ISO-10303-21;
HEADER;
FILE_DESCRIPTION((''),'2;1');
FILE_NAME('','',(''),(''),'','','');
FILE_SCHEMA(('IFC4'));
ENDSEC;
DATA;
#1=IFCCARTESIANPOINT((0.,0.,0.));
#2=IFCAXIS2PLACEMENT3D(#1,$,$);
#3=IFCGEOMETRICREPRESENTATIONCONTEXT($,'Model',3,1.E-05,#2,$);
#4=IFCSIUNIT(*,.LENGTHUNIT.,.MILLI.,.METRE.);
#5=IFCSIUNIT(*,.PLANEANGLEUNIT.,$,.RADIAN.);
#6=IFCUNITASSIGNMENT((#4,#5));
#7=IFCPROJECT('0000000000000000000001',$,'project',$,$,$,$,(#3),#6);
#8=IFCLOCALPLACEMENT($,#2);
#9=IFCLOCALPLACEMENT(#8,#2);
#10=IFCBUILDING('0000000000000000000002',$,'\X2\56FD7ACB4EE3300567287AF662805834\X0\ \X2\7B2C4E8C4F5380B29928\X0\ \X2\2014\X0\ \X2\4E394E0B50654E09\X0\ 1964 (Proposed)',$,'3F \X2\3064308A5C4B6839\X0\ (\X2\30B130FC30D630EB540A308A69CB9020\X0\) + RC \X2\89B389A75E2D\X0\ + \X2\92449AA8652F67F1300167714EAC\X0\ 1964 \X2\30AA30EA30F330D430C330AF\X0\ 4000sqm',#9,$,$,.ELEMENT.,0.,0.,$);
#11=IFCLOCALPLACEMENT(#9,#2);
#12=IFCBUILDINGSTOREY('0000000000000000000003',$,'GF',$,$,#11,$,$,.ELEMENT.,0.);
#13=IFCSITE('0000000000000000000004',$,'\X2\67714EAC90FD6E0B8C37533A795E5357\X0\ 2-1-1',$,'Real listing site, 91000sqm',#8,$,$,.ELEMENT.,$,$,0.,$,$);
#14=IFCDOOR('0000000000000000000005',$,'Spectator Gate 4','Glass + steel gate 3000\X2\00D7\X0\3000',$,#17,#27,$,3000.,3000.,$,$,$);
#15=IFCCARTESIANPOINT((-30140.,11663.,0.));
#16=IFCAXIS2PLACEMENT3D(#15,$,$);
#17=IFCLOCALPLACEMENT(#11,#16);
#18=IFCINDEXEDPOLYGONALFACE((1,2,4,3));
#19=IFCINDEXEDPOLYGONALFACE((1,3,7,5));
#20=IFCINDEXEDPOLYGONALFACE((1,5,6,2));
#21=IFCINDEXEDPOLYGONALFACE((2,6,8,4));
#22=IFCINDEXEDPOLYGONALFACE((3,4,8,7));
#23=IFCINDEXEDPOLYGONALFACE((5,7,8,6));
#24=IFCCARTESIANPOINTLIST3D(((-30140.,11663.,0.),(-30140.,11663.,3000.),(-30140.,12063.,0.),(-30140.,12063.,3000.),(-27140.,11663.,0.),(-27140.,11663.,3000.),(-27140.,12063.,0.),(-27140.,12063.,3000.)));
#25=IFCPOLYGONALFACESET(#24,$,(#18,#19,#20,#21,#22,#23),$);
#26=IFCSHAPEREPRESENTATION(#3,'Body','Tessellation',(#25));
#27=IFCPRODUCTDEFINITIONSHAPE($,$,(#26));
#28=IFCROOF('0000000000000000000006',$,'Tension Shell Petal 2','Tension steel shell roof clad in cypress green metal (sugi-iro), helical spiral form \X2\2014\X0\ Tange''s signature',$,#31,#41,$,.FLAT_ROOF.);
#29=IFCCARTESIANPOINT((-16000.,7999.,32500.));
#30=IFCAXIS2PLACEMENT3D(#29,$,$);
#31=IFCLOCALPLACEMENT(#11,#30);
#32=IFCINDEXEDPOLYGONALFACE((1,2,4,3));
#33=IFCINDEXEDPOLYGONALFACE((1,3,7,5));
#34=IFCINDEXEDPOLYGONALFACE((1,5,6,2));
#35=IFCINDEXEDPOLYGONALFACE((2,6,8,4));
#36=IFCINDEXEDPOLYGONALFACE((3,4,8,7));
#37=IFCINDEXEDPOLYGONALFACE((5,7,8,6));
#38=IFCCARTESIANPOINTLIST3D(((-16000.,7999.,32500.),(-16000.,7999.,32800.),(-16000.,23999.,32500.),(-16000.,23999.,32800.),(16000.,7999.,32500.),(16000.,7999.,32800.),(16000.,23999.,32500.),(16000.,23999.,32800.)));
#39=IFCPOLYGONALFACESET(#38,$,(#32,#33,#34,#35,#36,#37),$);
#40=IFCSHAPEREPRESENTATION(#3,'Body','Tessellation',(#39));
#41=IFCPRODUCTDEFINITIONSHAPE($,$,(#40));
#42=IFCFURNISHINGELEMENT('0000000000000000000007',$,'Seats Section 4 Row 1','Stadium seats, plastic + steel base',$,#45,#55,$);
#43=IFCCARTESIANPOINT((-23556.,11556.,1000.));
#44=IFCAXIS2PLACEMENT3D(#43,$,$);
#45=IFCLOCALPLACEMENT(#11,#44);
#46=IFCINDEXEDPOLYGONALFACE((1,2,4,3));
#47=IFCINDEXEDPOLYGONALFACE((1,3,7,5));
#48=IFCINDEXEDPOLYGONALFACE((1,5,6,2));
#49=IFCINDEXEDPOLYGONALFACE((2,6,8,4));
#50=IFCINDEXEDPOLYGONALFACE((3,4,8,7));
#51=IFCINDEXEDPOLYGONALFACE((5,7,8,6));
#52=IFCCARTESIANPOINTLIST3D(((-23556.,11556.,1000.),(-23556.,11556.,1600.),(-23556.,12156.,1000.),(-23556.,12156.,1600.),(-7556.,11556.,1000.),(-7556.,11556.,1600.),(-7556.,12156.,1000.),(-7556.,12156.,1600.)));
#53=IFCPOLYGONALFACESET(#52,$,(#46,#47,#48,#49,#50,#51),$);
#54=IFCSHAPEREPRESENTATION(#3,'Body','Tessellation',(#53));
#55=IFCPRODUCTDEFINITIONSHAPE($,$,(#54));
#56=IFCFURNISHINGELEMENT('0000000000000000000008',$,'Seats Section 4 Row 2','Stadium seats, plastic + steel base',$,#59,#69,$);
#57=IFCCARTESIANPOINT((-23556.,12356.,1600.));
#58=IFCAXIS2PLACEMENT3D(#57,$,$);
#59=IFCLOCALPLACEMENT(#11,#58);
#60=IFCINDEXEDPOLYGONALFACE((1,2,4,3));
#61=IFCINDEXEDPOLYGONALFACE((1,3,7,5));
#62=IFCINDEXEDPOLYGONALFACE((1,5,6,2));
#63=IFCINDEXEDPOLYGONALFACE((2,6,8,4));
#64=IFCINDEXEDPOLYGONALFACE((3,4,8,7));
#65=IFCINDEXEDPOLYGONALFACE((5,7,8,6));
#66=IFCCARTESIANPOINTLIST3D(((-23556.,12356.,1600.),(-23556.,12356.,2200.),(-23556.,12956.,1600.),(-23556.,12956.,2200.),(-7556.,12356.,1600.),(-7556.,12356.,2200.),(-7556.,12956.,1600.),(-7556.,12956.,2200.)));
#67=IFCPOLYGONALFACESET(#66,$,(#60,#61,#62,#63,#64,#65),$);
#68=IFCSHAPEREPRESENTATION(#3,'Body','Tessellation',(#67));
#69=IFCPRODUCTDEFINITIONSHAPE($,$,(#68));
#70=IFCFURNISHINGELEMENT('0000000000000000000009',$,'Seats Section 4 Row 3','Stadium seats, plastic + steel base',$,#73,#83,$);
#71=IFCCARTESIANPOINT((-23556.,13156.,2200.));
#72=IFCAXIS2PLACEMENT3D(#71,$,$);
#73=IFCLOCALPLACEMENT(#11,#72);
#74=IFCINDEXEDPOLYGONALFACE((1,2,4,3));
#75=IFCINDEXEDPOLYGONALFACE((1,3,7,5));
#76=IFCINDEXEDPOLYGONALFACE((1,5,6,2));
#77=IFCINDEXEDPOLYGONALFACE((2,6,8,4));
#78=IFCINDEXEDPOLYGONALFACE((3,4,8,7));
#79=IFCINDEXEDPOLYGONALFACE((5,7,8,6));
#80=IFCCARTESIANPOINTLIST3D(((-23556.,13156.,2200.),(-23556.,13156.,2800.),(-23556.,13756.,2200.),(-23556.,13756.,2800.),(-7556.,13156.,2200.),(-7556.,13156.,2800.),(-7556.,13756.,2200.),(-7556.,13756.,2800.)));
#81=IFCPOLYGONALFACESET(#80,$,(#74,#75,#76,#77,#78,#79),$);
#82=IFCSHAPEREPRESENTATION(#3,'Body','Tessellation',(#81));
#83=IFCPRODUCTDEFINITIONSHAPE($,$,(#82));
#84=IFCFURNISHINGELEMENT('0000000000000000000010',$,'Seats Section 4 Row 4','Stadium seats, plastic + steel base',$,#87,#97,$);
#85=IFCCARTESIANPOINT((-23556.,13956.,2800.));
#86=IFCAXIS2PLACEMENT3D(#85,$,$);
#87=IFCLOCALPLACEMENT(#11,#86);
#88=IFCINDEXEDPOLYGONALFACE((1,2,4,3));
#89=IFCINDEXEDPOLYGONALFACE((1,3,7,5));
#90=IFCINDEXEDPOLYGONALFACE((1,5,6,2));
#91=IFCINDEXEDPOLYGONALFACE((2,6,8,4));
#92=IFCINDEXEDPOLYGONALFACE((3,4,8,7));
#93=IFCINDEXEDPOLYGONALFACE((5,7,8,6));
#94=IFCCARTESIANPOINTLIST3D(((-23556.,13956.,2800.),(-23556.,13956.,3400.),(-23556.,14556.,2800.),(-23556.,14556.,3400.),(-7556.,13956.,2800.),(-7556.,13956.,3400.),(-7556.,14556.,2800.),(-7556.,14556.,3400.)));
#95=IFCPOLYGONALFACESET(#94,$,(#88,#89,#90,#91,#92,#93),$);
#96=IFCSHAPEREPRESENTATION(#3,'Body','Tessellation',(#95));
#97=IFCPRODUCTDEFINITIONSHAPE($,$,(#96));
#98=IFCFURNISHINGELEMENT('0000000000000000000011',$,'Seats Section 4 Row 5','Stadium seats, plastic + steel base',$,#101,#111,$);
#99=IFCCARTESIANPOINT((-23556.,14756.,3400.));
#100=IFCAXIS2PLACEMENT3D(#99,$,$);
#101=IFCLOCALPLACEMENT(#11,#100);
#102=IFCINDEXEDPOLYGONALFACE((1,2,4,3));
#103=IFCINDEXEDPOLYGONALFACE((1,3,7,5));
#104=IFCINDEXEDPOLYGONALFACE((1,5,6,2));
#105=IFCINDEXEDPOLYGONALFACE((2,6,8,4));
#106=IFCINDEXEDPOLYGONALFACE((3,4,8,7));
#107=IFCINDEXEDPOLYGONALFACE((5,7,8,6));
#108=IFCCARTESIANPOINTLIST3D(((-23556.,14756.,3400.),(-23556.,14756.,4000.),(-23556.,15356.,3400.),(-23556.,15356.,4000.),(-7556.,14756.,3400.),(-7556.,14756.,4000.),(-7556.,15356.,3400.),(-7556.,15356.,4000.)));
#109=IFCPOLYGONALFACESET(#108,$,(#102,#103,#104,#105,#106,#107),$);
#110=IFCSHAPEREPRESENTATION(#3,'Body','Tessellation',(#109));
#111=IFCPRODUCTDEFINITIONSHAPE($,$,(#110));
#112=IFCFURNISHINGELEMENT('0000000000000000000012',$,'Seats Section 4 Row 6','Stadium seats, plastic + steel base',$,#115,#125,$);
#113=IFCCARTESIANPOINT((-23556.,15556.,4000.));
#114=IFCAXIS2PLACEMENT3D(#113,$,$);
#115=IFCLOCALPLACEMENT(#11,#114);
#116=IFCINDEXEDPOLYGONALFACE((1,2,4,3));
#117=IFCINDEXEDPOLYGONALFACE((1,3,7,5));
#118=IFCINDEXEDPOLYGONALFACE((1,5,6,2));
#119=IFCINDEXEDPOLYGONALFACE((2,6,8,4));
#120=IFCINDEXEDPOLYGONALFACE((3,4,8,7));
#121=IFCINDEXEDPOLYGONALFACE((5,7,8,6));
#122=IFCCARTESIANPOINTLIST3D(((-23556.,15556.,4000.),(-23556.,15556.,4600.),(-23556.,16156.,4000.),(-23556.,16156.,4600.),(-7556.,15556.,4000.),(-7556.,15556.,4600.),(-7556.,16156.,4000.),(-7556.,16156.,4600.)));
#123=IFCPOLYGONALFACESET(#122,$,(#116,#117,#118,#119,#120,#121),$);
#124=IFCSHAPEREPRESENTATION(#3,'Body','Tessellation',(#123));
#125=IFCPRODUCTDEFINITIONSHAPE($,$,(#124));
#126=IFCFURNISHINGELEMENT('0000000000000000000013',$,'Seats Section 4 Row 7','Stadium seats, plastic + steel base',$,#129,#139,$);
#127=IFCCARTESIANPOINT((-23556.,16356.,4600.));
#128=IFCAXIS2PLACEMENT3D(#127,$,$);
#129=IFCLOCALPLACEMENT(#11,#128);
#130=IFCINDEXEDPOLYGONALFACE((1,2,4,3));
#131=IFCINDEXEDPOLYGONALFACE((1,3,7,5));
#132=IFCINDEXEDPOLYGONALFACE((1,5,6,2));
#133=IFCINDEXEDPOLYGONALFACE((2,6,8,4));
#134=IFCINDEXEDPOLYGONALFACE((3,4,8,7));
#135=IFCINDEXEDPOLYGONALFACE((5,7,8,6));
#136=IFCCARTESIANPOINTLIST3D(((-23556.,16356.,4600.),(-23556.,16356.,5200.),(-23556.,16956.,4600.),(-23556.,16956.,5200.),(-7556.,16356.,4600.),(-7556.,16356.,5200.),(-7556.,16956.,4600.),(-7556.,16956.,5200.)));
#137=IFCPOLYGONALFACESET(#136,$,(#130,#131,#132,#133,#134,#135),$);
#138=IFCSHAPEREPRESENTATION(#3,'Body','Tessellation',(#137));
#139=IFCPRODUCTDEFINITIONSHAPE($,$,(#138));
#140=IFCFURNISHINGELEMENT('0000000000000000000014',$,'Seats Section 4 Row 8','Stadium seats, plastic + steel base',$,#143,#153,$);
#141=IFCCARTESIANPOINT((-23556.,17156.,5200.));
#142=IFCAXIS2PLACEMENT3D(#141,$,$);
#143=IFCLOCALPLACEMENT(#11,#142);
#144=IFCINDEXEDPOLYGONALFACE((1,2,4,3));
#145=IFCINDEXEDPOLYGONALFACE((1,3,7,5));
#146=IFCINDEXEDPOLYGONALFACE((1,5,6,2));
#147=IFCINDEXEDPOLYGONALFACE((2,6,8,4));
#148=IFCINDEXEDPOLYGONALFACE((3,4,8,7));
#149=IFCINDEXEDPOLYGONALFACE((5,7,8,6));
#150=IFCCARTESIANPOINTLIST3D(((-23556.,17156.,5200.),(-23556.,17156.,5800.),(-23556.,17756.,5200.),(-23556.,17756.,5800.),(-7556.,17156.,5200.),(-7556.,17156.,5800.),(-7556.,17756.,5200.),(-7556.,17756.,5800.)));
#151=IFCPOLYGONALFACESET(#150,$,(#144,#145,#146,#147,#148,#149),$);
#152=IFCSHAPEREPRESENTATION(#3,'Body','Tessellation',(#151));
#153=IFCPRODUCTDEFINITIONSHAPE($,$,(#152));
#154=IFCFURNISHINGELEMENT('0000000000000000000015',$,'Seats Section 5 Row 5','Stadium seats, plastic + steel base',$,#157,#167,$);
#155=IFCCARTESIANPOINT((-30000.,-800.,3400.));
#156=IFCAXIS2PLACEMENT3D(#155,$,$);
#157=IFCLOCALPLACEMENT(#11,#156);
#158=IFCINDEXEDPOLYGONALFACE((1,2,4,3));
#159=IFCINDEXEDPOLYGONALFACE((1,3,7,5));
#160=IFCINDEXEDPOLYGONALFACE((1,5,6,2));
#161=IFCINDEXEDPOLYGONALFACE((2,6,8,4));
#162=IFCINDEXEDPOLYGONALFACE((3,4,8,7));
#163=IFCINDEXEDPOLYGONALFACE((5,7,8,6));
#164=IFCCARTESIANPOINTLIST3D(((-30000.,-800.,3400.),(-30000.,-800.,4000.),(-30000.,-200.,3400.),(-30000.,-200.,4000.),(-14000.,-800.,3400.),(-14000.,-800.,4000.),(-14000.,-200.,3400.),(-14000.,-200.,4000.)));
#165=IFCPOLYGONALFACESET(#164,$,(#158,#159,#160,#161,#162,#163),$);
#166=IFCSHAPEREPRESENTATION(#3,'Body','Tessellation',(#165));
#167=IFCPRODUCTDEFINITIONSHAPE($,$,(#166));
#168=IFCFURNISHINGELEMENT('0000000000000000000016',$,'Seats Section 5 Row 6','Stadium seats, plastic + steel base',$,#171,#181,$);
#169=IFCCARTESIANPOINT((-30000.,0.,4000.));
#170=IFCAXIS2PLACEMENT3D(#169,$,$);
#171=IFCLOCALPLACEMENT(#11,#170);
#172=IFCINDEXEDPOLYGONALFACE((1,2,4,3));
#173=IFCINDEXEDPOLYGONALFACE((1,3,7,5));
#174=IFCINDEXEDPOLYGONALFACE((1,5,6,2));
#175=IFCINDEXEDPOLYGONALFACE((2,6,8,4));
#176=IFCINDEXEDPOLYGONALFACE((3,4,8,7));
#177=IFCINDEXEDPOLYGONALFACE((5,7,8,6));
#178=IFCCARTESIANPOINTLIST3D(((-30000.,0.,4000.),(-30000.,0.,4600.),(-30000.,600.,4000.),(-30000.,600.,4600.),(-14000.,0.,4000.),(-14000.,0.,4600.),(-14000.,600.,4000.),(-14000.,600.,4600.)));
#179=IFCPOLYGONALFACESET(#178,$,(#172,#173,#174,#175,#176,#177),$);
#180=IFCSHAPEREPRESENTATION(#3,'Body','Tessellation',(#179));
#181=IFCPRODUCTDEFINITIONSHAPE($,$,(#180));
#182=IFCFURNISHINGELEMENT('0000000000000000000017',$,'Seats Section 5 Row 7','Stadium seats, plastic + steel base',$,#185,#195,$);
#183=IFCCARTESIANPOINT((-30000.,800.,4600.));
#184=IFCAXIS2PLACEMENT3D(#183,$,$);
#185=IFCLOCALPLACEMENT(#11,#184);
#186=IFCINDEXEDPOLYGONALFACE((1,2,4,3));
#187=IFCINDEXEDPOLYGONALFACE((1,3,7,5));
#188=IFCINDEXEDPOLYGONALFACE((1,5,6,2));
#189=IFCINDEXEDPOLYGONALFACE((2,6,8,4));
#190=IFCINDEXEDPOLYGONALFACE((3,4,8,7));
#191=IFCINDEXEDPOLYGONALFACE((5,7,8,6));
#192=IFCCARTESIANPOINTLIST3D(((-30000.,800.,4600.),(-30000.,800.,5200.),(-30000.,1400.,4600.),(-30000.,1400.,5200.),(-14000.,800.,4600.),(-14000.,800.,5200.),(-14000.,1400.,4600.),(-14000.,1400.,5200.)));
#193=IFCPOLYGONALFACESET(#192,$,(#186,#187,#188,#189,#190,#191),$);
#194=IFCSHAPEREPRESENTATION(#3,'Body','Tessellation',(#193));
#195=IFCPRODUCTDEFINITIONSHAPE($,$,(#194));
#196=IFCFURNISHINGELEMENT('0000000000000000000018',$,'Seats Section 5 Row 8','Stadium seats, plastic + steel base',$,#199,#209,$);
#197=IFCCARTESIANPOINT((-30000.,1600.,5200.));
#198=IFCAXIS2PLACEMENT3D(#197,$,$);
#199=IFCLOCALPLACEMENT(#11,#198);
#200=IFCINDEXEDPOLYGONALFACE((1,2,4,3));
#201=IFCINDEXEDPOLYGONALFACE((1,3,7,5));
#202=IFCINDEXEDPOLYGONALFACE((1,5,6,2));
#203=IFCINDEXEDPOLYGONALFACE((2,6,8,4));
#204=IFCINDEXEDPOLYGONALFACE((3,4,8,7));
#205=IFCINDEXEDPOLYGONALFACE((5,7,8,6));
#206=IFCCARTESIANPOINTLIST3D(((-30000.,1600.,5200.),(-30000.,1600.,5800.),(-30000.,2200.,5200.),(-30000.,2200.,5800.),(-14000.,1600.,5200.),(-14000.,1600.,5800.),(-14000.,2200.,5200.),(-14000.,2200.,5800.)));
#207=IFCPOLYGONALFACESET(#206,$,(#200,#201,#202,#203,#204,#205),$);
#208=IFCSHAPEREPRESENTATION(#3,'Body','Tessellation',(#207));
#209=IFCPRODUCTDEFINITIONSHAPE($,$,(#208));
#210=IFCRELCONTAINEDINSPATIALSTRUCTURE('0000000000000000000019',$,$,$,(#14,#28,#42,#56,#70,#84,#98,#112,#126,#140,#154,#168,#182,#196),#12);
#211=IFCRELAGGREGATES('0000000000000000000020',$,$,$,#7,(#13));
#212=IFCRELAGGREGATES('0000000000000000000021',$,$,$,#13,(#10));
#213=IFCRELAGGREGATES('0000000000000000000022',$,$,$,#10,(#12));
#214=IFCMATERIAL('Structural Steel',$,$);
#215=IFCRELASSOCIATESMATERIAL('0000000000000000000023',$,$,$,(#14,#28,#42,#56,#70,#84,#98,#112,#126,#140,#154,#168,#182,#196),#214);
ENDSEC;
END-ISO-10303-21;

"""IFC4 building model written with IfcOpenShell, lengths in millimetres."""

from ifc_helpers import new_model, si_unit, frame, frame_2d, origin, place, context, project, spatial, rectangle, extrude, material, element, save


model = new_model("IFC4")

# Units and contexts
model_context = context("Model", 3, precision=1e-05, world=origin())
ifc_project = project(units=[si_unit("LENGTHUNIT", "METRE", prefix="MILLI"), si_unit("PLANEANGLEUNIT", "RADIAN")], contexts=[model_context])

# Site, building, storey
site_placement = place(None, origin())
site = spatial("IfcSite", under=ifc_project, at=site_placement, Name="東京都渋谷区神南 2-1-1", ObjectType="Real listing site, 91000sqm", CompositionType="ELEMENT", RefElevation=0.0)
building_placement = place(site_placement, origin())
building = spatial("IfcBuilding", under=site, at=building_placement, Name="国立代々木競技場 第二体育館 — 丹下健三 1964 (Proposed)", ObjectType="3F つり屋根 (ケーブル吊り構造) + RC 観覧席 + 鉄骨支柱、東京 1964 オリンピック 4000sqm", CompositionType="ELEMENT", ElevationOfRefHeight=0.0, ElevationOfTerrain=0.0)
storey_placement = place(building_placement, origin())
storey = spatial("IfcBuildingStorey", under=building, at=storey_placement, Name="GF", CompositionType="ELEMENT", Elevation=0.0)

# Door
ifc_material_1 = material(Name="Structural Steel")
door_placement = place(storey_placement, frame((-30140.0, 11663.0, 0.0)))
element("IfcDoor", 1, at=door_placement, inside=storey, material=ifc_material_1, Name="Spectator Gate 4", Description="Glass + steel gate 3000×3000", OverallHeight=3000.0, OverallWidth=3000.0, context=model_context, shape_type="SweptSolid", body=[
    extrude(rectangle(XDim=3000.0, YDim=400.0, at=frame_2d((1500.0, 200.0))), frame((-30140.0, 11663.0, 0.0)), (0.0, 0.0, 1.0), 3000.0),
])

# Roof
roof_placement = place(storey_placement, frame((-16000.0, 7999.0, 32500.0)))
element("IfcRoof", 2, at=roof_placement, inside=storey, material=ifc_material_1, Name="Tension Shell Petal 2", Description="Tension steel shell roof clad in cypress green metal (sugi-iro), helical spiral form — Tange's signature", PredefinedType="FLAT_ROOF", context=model_context, shape_type="SweptSolid", body=[
    extrude(rectangle(XDim=32000.0, YDim=16000.0, at=frame_2d((16000.0, 8000.0))), frame((-16000.0, 7999.0, 32500.0)), (0.0, 0.0, 1.0), 300.0),
])

# Furnishing elements
furnishing_1_placement = place(storey_placement, frame((-23556.0, 11556.0, 1000.0)))
element("IfcFurnishingElement", 3, at=furnishing_1_placement, inside=storey, material=ifc_material_1, Name="Seats Section 4 Row 1", Description="Stadium seats, plastic + steel base", context=model_context, shape_type="SweptSolid", body=[
    extrude(rectangle(XDim=16000.0, YDim=600.0, at=frame_2d((8000.0, 300.0))), frame((-23556.0, 11556.0, 1000.0)), (0.0, 0.0, 1.0), 600.0),
])
furnishing_2_placement = place(storey_placement, frame((-23556.0, 12356.0, 1600.0)))
element("IfcFurnishingElement", 4, at=furnishing_2_placement, inside=storey, material=ifc_material_1, Name="Seats Section 4 Row 2", Description="Stadium seats, plastic + steel base", context=model_context, shape_type="SweptSolid", body=[
    extrude(rectangle(XDim=16000.0, YDim=600.0, at=frame_2d((8000.0, 300.0))), frame((-23556.0, 12356.0, 1600.0)), (0.0, 0.0, 1.0), 600.0),
])
furnishing_3_placement = place(storey_placement, frame((-23556.0, 13156.0, 2200.0)))
element("IfcFurnishingElement", 5, at=furnishing_3_placement, inside=storey, material=ifc_material_1, Name="Seats Section 4 Row 3", Description="Stadium seats, plastic + steel base", context=model_context, shape_type="SweptSolid", body=[
    extrude(rectangle(XDim=16000.0, YDim=600.0, at=frame_2d((8000.0, 300.0))), frame((-23556.0, 13156.0, 2200.0)), (0.0, 0.0, 1.0), 600.0),
])
furnishing_4_placement = place(storey_placement, frame((-23556.0, 13956.0, 2800.0)))
element("IfcFurnishingElement", 6, at=furnishing_4_placement, inside=storey, material=ifc_material_1, Name="Seats Section 4 Row 4", Description="Stadium seats, plastic + steel base", context=model_context, shape_type="SweptSolid", body=[
    extrude(rectangle(XDim=16000.0, YDim=600.0, at=frame_2d((8000.0, 300.0))), frame((-23556.0, 13956.0, 2800.0)), (0.0, 0.0, 1.0), 600.0),
])
furnishing_5_placement = place(storey_placement, frame((-23556.0, 14756.0, 3400.0)))
element("IfcFurnishingElement", 7, at=furnishing_5_placement, inside=storey, material=ifc_material_1, Name="Seats Section 4 Row 5", Description="Stadium seats, plastic + steel base", context=model_context, shape_type="SweptSolid", body=[
    extrude(rectangle(XDim=16000.0, YDim=600.0, at=frame_2d((8000.0, 300.0))), frame((-23556.0, 14756.0, 3400.0)), (0.0, 0.0, 1.0), 600.0),
])
furnishing_6_placement = place(storey_placement, frame((-23556.0, 15556.0, 4000.0)))
element("IfcFurnishingElement", 8, at=furnishing_6_placement, inside=storey, material=ifc_material_1, Name="Seats Section 4 Row 6", Description="Stadium seats, plastic + steel base", context=model_context, shape_type="SweptSolid", body=[
    extrude(rectangle(XDim=16000.0, YDim=600.0, at=frame_2d((8000.0, 300.0))), frame((-23556.0, 15556.0, 4000.0)), (0.0, 0.0, 1.0), 600.0),
])
furnishing_7_placement = place(storey_placement, frame((-23556.0, 16356.0, 4600.0)))
element("IfcFurnishingElement", 9, at=furnishing_7_placement, inside=storey, material=ifc_material_1, Name="Seats Section 4 Row 7", Description="Stadium seats, plastic + steel base", context=model_context, shape_type="SweptSolid", body=[
    extrude(rectangle(XDim=16000.0, YDim=600.0, at=frame_2d((8000.0, 300.0))), frame((-23556.0, 16356.0, 4600.0)), (0.0, 0.0, 1.0), 600.0),
])
furnishing_8_placement = place(storey_placement, frame((-23556.0, 17156.0, 5200.0)))
element("IfcFurnishingElement", 10, at=furnishing_8_placement, inside=storey, material=ifc_material_1, Name="Seats Section 4 Row 8", Description="Stadium seats, plastic + steel base", context=model_context, shape_type="SweptSolid", body=[
    extrude(rectangle(XDim=16000.0, YDim=600.0, at=frame_2d((8000.0, 300.0))), frame((-23556.0, 17156.0, 5200.0)), (0.0, 0.0, 1.0), 600.0),
])
furnishing_9_placement = place(storey_placement, frame((-30000.0, -800.0, 3400.0)))
element("IfcFurnishingElement", 11, at=furnishing_9_placement, inside=storey, material=ifc_material_1, Name="Seats Section 5 Row 5", Description="Stadium seats, plastic + steel base", context=model_context, shape_type="SweptSolid", body=[
    extrude(rectangle(XDim=16000.0, YDim=600.0, at=frame_2d((8000.0, 300.0))), frame((-30000.0, -800.0, 3400.0)), (0.0, 0.0, 1.0), 600.0),
])
furnishing_10_placement = place(storey_placement, frame((-30000.0, 0.0, 4000.0)))
element("IfcFurnishingElement", 12, at=furnishing_10_placement, inside=storey, material=ifc_material_1, Name="Seats Section 5 Row 6", Description="Stadium seats, plastic + steel base", context=model_context, shape_type="SweptSolid", body=[
    extrude(rectangle(XDim=16000.0, YDim=600.0, at=frame_2d((8000.0, 300.0))), frame((-30000.0, 0.0, 4000.0)), (0.0, 0.0, 1.0), 600.0),
])
furnishing_11_placement = place(storey_placement, frame((-30000.0, 800.0, 4600.0)))
element("IfcFurnishingElement", 13, at=furnishing_11_placement, inside=storey, material=ifc_material_1, Name="Seats Section 5 Row 7", Description="Stadium seats, plastic + steel base", context=model_context, shape_type="SweptSolid", body=[
    extrude(rectangle(XDim=16000.0, YDim=600.0, at=frame_2d((8000.0, 300.0))), frame((-30000.0, 800.0, 4600.0)), (0.0, 0.0, 1.0), 600.0),
])
furnishing_12_placement = place(storey_placement, frame((-30000.0, 1600.0, 5200.0)))
element("IfcFurnishingElement", 14, at=furnishing_12_placement, inside=storey, material=ifc_material_1, Name="Seats Section 5 Row 8", Description="Stadium seats, plastic + steel base", context=model_context, shape_type="SweptSolid", body=[
    extrude(rectangle(XDim=16000.0, YDim=600.0, at=frame_2d((8000.0, 300.0))), frame((-30000.0, 1600.0, 5200.0)), (0.0, 0.0, 1.0), 600.0),
])

save(model, "model.ifc")
